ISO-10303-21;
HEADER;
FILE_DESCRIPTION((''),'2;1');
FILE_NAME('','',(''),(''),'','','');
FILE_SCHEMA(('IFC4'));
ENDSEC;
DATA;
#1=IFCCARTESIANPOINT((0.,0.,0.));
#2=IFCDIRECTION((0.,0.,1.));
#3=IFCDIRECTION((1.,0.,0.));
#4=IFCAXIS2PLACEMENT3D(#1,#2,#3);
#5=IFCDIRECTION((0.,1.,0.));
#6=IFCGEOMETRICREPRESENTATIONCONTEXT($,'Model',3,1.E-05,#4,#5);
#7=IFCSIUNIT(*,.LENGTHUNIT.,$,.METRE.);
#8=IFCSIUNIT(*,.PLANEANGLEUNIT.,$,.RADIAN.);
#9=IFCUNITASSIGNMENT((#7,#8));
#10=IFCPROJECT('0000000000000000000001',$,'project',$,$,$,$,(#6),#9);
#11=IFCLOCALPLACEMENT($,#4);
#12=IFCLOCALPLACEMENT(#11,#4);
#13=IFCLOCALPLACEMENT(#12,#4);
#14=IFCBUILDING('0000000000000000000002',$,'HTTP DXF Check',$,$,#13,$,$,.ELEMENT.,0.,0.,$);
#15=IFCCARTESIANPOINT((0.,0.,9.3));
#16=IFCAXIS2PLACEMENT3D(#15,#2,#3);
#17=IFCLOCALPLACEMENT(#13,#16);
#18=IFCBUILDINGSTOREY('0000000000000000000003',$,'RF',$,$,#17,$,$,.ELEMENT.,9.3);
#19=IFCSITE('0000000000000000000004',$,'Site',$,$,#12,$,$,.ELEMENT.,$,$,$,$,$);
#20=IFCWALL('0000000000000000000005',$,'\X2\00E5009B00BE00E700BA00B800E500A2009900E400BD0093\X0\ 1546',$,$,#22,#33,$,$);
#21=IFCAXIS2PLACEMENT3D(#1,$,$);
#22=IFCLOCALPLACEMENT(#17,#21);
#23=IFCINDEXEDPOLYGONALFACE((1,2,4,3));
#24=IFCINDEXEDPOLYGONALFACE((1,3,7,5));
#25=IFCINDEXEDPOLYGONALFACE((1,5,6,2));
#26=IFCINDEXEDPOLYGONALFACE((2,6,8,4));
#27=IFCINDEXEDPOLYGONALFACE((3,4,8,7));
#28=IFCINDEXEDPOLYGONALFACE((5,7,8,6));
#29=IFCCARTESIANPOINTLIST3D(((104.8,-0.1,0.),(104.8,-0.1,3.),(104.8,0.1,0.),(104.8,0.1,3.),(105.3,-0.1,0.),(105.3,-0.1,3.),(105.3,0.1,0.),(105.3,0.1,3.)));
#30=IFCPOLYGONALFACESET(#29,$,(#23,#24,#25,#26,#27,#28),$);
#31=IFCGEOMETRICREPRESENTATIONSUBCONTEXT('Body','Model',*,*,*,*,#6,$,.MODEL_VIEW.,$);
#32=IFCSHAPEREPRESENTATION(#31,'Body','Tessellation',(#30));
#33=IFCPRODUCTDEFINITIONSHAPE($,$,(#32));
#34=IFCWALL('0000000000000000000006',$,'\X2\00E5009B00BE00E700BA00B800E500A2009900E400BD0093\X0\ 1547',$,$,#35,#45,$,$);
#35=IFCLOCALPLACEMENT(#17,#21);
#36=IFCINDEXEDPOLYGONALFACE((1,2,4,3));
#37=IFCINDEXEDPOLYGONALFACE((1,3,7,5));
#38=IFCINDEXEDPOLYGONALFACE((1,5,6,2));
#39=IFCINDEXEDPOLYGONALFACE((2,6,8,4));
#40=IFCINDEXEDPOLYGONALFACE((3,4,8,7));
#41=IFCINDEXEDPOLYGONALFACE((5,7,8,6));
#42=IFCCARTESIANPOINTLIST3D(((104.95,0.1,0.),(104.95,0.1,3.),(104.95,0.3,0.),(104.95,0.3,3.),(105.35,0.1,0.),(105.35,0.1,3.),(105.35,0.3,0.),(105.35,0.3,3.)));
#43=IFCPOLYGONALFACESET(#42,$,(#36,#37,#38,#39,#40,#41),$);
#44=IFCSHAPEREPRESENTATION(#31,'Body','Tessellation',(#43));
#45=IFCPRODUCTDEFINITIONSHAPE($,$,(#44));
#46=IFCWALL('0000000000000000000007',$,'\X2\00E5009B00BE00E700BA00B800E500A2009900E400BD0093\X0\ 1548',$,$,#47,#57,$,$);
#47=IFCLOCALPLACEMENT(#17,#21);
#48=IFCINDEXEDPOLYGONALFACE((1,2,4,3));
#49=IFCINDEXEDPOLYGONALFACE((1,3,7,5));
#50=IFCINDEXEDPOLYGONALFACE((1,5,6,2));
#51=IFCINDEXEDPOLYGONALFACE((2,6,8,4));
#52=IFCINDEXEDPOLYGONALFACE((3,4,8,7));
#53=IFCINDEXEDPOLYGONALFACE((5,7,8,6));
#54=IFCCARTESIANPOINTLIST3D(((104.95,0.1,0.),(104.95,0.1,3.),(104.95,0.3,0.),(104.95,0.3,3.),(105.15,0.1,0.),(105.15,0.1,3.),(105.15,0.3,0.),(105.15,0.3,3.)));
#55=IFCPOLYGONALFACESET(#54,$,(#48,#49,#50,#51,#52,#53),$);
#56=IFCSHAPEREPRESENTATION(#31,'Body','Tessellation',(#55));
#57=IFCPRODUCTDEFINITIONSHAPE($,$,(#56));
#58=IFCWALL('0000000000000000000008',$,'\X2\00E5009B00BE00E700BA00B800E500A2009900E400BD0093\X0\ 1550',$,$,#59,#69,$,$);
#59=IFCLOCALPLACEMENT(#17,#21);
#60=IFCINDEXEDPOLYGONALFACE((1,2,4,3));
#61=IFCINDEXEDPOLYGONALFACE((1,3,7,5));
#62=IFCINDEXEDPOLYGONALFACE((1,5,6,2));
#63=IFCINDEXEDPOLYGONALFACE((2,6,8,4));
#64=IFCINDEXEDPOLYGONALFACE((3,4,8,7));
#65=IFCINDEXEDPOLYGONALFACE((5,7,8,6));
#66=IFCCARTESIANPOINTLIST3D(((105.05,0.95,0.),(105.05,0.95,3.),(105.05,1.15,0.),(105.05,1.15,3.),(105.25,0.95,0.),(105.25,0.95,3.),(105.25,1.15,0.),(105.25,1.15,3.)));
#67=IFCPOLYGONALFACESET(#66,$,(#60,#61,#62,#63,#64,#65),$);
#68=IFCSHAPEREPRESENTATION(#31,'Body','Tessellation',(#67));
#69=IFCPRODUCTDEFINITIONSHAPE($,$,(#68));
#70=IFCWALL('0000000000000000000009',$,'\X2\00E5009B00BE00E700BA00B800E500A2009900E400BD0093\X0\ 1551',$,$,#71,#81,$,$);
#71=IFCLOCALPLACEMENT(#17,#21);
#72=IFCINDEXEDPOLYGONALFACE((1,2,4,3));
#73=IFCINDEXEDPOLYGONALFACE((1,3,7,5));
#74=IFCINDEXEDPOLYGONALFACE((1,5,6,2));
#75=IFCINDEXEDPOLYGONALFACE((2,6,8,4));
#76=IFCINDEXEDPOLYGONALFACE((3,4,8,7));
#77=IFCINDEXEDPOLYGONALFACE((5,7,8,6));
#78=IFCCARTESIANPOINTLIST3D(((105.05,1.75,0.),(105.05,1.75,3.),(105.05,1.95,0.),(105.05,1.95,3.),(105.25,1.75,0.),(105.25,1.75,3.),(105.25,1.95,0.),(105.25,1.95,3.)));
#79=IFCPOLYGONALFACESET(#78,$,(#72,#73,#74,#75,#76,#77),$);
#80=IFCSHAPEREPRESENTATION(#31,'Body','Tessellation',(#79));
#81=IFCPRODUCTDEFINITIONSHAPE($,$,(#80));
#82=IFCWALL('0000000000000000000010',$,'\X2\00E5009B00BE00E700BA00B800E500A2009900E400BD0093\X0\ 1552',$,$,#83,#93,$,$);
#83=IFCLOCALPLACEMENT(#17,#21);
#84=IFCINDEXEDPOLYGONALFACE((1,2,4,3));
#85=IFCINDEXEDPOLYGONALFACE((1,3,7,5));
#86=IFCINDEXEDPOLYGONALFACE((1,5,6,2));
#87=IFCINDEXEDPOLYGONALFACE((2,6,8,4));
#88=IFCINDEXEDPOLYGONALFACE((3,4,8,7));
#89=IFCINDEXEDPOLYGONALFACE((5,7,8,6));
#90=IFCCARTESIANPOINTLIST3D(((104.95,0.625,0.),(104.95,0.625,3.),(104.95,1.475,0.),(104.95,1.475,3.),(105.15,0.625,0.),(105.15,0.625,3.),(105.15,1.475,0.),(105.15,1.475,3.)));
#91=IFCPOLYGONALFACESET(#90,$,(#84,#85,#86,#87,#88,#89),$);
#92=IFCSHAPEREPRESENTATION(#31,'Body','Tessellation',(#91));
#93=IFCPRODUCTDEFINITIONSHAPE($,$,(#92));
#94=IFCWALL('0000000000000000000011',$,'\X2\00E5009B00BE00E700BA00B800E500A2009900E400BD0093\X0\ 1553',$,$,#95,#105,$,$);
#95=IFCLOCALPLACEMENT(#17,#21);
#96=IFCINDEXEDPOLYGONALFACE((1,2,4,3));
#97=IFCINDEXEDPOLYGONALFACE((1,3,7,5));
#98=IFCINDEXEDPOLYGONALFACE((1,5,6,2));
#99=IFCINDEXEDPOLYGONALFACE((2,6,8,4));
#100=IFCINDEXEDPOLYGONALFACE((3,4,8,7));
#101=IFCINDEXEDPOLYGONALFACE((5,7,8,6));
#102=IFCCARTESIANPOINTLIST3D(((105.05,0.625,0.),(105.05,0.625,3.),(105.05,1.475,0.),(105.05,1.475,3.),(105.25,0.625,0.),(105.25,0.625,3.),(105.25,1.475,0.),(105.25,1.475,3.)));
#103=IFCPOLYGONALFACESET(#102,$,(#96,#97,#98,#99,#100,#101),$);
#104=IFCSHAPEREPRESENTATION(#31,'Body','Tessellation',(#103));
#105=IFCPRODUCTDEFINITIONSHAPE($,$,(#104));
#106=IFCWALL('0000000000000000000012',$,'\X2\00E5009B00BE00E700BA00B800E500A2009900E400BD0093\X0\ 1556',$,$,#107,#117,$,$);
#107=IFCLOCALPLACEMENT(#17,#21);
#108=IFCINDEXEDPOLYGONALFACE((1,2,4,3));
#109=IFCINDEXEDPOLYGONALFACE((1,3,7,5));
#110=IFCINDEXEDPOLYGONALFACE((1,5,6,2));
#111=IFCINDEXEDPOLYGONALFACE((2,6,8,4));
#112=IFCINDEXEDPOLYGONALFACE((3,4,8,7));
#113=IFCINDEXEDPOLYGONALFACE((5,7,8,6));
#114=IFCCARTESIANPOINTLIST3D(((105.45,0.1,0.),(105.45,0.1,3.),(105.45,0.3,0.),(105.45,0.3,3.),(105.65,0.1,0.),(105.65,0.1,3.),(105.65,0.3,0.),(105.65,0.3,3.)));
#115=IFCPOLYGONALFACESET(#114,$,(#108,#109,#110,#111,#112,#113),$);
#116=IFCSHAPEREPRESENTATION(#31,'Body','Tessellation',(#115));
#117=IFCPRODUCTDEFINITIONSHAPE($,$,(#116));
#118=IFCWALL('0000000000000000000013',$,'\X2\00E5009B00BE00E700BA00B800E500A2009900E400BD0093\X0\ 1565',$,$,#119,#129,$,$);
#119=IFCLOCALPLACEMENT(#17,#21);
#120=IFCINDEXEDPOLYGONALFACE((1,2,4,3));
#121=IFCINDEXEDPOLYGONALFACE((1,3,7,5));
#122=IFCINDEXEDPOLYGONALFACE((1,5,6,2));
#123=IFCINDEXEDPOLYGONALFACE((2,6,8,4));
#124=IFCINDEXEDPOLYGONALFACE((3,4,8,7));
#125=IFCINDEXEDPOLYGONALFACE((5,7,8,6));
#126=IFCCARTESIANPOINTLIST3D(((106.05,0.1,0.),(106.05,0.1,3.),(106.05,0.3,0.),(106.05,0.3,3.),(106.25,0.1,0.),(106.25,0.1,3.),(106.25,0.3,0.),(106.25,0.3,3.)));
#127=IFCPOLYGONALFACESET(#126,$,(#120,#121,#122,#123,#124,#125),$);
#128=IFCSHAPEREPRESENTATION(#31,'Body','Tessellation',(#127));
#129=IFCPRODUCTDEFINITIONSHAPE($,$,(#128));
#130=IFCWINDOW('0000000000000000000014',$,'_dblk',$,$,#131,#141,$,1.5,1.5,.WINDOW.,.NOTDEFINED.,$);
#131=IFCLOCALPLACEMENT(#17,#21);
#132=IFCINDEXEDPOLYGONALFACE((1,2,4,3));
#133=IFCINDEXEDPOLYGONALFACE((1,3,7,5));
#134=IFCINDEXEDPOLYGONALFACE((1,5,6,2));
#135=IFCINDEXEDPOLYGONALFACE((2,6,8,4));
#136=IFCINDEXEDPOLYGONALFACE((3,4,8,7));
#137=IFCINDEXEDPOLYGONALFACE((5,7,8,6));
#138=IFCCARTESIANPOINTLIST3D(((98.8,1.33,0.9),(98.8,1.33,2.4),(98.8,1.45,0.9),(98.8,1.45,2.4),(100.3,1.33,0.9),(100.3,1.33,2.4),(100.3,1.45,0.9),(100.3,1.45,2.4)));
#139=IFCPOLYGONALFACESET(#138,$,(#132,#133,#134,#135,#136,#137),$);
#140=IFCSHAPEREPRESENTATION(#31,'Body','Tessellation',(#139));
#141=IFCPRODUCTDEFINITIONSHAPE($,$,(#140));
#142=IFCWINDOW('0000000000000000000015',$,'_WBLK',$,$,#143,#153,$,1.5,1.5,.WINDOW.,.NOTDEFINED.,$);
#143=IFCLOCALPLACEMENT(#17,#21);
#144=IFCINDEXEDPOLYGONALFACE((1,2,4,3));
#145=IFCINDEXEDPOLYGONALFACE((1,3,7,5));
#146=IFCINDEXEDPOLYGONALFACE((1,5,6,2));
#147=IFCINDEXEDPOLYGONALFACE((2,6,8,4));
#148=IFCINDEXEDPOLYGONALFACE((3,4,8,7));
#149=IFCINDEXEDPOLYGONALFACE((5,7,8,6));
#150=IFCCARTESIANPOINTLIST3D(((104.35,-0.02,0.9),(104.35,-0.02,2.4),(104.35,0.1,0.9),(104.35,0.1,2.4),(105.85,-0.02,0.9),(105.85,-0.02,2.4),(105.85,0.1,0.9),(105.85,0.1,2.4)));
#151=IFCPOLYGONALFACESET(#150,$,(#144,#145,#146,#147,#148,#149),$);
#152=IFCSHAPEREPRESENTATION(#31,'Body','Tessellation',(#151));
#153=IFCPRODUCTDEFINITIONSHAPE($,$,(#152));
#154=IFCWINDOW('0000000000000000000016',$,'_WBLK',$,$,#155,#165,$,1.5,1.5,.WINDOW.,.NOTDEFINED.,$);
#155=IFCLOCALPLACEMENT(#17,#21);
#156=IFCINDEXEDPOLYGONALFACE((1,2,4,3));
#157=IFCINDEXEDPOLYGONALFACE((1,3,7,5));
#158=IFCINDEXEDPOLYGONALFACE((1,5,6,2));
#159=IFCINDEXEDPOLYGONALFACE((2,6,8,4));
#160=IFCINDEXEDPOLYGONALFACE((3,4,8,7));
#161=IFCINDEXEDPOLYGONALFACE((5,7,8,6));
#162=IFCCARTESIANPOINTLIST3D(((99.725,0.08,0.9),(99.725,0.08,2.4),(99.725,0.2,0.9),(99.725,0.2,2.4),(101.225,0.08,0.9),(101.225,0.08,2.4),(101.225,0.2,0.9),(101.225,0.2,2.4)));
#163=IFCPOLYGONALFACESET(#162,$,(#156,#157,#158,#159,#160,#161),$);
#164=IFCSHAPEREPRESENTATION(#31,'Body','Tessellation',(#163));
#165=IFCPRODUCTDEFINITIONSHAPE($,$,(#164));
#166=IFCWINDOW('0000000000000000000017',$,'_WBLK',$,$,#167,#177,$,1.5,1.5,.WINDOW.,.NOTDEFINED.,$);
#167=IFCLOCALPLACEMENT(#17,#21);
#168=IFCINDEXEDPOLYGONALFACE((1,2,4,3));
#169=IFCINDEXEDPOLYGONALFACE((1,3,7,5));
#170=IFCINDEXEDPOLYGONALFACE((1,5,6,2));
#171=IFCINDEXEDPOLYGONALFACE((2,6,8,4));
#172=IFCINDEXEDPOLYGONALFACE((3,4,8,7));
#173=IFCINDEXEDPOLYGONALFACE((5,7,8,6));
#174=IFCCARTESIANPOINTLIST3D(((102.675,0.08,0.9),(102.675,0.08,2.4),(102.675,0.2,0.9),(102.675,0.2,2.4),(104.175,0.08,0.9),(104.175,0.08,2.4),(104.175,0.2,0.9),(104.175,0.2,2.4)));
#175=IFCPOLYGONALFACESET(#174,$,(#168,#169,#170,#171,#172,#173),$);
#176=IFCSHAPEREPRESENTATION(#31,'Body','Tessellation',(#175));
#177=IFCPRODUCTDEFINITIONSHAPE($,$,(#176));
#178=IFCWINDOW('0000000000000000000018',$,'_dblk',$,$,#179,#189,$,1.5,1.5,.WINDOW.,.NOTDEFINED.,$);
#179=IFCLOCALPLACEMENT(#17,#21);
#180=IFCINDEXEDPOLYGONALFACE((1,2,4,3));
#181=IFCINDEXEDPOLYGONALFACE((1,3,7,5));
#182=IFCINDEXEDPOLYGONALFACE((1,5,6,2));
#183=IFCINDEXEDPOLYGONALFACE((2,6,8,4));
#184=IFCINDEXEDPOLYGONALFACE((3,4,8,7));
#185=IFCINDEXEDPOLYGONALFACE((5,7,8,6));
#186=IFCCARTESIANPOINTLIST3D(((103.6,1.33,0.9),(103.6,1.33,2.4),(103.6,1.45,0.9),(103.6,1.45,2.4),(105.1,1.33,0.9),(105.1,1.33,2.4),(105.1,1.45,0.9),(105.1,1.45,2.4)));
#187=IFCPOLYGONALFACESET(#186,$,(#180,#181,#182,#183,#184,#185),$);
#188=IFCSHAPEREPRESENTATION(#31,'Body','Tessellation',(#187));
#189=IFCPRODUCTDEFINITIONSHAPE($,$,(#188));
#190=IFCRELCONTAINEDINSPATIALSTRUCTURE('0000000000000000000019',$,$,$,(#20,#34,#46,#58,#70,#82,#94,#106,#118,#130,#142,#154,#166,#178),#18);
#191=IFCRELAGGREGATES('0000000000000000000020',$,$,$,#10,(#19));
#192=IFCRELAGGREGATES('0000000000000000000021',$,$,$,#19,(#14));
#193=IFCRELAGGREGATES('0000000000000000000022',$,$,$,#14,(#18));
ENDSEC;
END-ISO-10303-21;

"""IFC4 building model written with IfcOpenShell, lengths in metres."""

from ifc_helpers import new_model, si_unit, direction, frame, frame_2d, origin_with_axes, place, context, subcontext, project, spatial, rectangle, extrude, element, save


model = new_model("IFC4")

# Units and contexts
model_context = context("Model", 3, precision=1e-05, world=origin_with_axes(), true_north=direction((0.0, 1.0, 0.0)))
body_context = subcontext(model_context, "Body", "Model", "MODEL_VIEW")
ifc_project = project(units=[si_unit("LENGTHUNIT", "METRE"), si_unit("PLANEANGLEUNIT", "RADIAN")], contexts=[model_context])

# Site, building, storey
placement = place(None, origin_with_axes())
site_placement = place(placement, origin_with_axes())
site = spatial("IfcSite", under=ifc_project, at=site_placement, Name="Site", CompositionType="ELEMENT")
building_placement = place(site_placement, origin_with_axes())
building = spatial("IfcBuilding", under=site, at=building_placement, Name="HTTP DXF Check", CompositionType="ELEMENT", ElevationOfRefHeight=0.0, ElevationOfTerrain=0.0)
storey_placement = place(building_placement, frame((0.0, 0.0, 9.3), z_axis=(0.0, 0.0, 1.0), x_axis=(1.0, 0.0, 0.0)))
storey = spatial("IfcBuildingStorey", under=building, at=storey_placement, Name="RF", CompositionType="ELEMENT", Elevation=9.3)

# Walls
wall_1_placement = place(storey_placement, frame((105.05, 0.0, 0.0), z_axis=(0.0, 0.0, 1.0), x_axis=(1.0, 0.0, 0.0)))
element("IfcWall", 1, at=wall_1_placement, inside=storey, Name="å\u009b¾çº¸å¢\u0099ä½\u0093 1546", context=body_context, shape_type="SweptSolid", body=[
    extrude(rectangle(XDim=0.5, YDim=0.2, at=frame_2d((0.0, 0.0), x_axis=(1.0, 0.0, 0.0))), frame((0.0, 0.0, 0.0), z_axis=(0.0, 0.0, 1.0)), (0.0, 0.0, 1.0), 3.0),
])
wall_2_placement = place(storey_placement, frame((105.15, 0.2, 0.0), z_axis=(0.0, 0.0, 1.0), x_axis=(1.0, 0.0, 0.0)))
element("IfcWall", 2, at=wall_2_placement, inside=storey, Name="å\u009b¾çº¸å¢\u0099ä½\u0093 1547", context=body_context, shape_type="SweptSolid", body=[
    extrude(rectangle(XDim=0.4, YDim=0.2, at=frame_2d((0.0, 0.0), x_axis=(1.0, 0.0, 0.0))), frame((0.0, 0.0, 0.0), z_axis=(0.0, 0.0, 1.0)), (0.0, 0.0, 1.0), 3.0),
])
for number, where, z_axis, x_axis, name in (
    (3, (105.05, 0.2, 0.0), (0.0, 0.0, 1.0), (0.0, -1.0, 0.0), "å\u009b¾çº¸å¢\u0099ä½\u0093 1548"),
    (4, (105.15, 1.05, 0.0), (0.0, 0.0, 1.0), (-1.0, 0.0, 0.0), "å\u009b¾çº¸å¢\u0099ä½\u0093 1550"),
    (5, (105.15, 1.85, 0.0), (0.0, 0.0, 1.0), (-1.0, 0.0, 0.0), "å\u009b¾çº¸å¢\u0099ä½\u0093 1551"),
):
    element("IfcWall", number, at=place(storey_placement, frame(where, z_axis=z_axis, x_axis=x_axis)), inside=storey, Name=name, context=body_context, shape_type="SweptSolid", body=[
        extrude(rectangle(XDim=0.2, YDim=0.2, at=frame_2d((0.0, 0.0), x_axis=(1.0, 0.0, 0.0))), frame((0.0, 0.0, 0.0), z_axis=(0.0, 0.0, 1.0)), (0.0, 0.0, 1.0), 3.0),
    ])
for number, where, z_axis, x_axis, name in (
    (6, (105.05, 1.05, 0.0), (0.0, 0.0, 1.0), (0.0, -1.0, 0.0), "å\u009b¾çº¸å¢\u0099ä½\u0093 1552"),
    (7, (105.15, 1.05, 0.0), (0.0, 0.0, 1.0), (0.0, -1.0, 0.0), "å\u009b¾çº¸å¢\u0099ä½\u0093 1553"),
):
    element("IfcWall", number, at=place(storey_placement, frame(where, z_axis=z_axis, x_axis=x_axis)), inside=storey, Name=name, context=body_context, shape_type="SweptSolid", body=[
        extrude(rectangle(XDim=0.85, YDim=0.2, at=frame_2d((0.0, 0.0), x_axis=(1.0, 0.0, 0.0))), frame((0.0, 0.0, 0.0), z_axis=(0.0, 0.0, 1.0)), (0.0, 0.0, 1.0), 3.0),
    ])
for number, where, z_axis, x_axis, name in (
    (8, (105.55, 0.2, 0.0), (0.0, 0.0, 1.0), (0.0, -1.0, 0.0), "å\u009b¾çº¸å¢\u0099ä½\u0093 1556"),
    (9, (106.15, 0.2, 0.0), (0.0, 0.0, 1.0), (0.0, -1.0, 0.0), "å\u009b¾çº¸å¢\u0099ä½\u0093 1565"),
):
    element("IfcWall", number, at=place(storey_placement, frame(where, z_axis=z_axis, x_axis=x_axis)), inside=storey, Name=name, context=body_context, shape_type="SweptSolid", body=[
        extrude(rectangle(XDim=0.2, YDim=0.2, at=frame_2d((0.0, 0.0), x_axis=(1.0, 0.0, 0.0))), frame((0.0, 0.0, 0.0), z_axis=(0.0, 0.0, 1.0)), (0.0, 0.0, 1.0), 3.0),
    ])

# Windows
for number, where, z_axis, x_axis, name in (
    (10, (99.55, 1.39, 0.9), (0.0, 0.0, 1.0), (1.0, 0.0, 0.0), "_dblk"),
    (11, (105.1, 0.04, 0.9), (0.0, 0.0, 1.0), (1.0, 0.0, 0.0), "_WBLK"),
    (12, (100.475, 0.14, 0.9), (0.0, 0.0, 1.0), (1.0, 0.0, 0.0), "_WBLK"),
    (13, (103.425, 0.14, 0.9), (0.0, 0.0, 1.0), (1.0, 0.0, 0.0), "_WBLK"),
    (14, (104.35, 1.39, 0.9), (0.0, 0.0, 1.0), (1.0, 0.0, 0.0), "_dblk"),
):
    element("IfcWindow", number, at=place(storey_placement, frame(where, z_axis=z_axis, x_axis=x_axis)), inside=storey, Name=name, OverallHeight=1.5, OverallWidth=1.5, PartitioningType="NOTDEFINED", PredefinedType="WINDOW", context=body_context, shape_type="SweptSolid", body=[
        extrude(rectangle(XDim=1.5, YDim=0.12, at=frame_2d((0.0, 0.0), x_axis=(1.0, 0.0, 0.0))), frame((0.0, 0.0, 0.0), z_axis=(0.0, 0.0, 1.0)), (0.0, 0.0, 1.0), 1.5),
    ])

save(model, "model.ifc")
